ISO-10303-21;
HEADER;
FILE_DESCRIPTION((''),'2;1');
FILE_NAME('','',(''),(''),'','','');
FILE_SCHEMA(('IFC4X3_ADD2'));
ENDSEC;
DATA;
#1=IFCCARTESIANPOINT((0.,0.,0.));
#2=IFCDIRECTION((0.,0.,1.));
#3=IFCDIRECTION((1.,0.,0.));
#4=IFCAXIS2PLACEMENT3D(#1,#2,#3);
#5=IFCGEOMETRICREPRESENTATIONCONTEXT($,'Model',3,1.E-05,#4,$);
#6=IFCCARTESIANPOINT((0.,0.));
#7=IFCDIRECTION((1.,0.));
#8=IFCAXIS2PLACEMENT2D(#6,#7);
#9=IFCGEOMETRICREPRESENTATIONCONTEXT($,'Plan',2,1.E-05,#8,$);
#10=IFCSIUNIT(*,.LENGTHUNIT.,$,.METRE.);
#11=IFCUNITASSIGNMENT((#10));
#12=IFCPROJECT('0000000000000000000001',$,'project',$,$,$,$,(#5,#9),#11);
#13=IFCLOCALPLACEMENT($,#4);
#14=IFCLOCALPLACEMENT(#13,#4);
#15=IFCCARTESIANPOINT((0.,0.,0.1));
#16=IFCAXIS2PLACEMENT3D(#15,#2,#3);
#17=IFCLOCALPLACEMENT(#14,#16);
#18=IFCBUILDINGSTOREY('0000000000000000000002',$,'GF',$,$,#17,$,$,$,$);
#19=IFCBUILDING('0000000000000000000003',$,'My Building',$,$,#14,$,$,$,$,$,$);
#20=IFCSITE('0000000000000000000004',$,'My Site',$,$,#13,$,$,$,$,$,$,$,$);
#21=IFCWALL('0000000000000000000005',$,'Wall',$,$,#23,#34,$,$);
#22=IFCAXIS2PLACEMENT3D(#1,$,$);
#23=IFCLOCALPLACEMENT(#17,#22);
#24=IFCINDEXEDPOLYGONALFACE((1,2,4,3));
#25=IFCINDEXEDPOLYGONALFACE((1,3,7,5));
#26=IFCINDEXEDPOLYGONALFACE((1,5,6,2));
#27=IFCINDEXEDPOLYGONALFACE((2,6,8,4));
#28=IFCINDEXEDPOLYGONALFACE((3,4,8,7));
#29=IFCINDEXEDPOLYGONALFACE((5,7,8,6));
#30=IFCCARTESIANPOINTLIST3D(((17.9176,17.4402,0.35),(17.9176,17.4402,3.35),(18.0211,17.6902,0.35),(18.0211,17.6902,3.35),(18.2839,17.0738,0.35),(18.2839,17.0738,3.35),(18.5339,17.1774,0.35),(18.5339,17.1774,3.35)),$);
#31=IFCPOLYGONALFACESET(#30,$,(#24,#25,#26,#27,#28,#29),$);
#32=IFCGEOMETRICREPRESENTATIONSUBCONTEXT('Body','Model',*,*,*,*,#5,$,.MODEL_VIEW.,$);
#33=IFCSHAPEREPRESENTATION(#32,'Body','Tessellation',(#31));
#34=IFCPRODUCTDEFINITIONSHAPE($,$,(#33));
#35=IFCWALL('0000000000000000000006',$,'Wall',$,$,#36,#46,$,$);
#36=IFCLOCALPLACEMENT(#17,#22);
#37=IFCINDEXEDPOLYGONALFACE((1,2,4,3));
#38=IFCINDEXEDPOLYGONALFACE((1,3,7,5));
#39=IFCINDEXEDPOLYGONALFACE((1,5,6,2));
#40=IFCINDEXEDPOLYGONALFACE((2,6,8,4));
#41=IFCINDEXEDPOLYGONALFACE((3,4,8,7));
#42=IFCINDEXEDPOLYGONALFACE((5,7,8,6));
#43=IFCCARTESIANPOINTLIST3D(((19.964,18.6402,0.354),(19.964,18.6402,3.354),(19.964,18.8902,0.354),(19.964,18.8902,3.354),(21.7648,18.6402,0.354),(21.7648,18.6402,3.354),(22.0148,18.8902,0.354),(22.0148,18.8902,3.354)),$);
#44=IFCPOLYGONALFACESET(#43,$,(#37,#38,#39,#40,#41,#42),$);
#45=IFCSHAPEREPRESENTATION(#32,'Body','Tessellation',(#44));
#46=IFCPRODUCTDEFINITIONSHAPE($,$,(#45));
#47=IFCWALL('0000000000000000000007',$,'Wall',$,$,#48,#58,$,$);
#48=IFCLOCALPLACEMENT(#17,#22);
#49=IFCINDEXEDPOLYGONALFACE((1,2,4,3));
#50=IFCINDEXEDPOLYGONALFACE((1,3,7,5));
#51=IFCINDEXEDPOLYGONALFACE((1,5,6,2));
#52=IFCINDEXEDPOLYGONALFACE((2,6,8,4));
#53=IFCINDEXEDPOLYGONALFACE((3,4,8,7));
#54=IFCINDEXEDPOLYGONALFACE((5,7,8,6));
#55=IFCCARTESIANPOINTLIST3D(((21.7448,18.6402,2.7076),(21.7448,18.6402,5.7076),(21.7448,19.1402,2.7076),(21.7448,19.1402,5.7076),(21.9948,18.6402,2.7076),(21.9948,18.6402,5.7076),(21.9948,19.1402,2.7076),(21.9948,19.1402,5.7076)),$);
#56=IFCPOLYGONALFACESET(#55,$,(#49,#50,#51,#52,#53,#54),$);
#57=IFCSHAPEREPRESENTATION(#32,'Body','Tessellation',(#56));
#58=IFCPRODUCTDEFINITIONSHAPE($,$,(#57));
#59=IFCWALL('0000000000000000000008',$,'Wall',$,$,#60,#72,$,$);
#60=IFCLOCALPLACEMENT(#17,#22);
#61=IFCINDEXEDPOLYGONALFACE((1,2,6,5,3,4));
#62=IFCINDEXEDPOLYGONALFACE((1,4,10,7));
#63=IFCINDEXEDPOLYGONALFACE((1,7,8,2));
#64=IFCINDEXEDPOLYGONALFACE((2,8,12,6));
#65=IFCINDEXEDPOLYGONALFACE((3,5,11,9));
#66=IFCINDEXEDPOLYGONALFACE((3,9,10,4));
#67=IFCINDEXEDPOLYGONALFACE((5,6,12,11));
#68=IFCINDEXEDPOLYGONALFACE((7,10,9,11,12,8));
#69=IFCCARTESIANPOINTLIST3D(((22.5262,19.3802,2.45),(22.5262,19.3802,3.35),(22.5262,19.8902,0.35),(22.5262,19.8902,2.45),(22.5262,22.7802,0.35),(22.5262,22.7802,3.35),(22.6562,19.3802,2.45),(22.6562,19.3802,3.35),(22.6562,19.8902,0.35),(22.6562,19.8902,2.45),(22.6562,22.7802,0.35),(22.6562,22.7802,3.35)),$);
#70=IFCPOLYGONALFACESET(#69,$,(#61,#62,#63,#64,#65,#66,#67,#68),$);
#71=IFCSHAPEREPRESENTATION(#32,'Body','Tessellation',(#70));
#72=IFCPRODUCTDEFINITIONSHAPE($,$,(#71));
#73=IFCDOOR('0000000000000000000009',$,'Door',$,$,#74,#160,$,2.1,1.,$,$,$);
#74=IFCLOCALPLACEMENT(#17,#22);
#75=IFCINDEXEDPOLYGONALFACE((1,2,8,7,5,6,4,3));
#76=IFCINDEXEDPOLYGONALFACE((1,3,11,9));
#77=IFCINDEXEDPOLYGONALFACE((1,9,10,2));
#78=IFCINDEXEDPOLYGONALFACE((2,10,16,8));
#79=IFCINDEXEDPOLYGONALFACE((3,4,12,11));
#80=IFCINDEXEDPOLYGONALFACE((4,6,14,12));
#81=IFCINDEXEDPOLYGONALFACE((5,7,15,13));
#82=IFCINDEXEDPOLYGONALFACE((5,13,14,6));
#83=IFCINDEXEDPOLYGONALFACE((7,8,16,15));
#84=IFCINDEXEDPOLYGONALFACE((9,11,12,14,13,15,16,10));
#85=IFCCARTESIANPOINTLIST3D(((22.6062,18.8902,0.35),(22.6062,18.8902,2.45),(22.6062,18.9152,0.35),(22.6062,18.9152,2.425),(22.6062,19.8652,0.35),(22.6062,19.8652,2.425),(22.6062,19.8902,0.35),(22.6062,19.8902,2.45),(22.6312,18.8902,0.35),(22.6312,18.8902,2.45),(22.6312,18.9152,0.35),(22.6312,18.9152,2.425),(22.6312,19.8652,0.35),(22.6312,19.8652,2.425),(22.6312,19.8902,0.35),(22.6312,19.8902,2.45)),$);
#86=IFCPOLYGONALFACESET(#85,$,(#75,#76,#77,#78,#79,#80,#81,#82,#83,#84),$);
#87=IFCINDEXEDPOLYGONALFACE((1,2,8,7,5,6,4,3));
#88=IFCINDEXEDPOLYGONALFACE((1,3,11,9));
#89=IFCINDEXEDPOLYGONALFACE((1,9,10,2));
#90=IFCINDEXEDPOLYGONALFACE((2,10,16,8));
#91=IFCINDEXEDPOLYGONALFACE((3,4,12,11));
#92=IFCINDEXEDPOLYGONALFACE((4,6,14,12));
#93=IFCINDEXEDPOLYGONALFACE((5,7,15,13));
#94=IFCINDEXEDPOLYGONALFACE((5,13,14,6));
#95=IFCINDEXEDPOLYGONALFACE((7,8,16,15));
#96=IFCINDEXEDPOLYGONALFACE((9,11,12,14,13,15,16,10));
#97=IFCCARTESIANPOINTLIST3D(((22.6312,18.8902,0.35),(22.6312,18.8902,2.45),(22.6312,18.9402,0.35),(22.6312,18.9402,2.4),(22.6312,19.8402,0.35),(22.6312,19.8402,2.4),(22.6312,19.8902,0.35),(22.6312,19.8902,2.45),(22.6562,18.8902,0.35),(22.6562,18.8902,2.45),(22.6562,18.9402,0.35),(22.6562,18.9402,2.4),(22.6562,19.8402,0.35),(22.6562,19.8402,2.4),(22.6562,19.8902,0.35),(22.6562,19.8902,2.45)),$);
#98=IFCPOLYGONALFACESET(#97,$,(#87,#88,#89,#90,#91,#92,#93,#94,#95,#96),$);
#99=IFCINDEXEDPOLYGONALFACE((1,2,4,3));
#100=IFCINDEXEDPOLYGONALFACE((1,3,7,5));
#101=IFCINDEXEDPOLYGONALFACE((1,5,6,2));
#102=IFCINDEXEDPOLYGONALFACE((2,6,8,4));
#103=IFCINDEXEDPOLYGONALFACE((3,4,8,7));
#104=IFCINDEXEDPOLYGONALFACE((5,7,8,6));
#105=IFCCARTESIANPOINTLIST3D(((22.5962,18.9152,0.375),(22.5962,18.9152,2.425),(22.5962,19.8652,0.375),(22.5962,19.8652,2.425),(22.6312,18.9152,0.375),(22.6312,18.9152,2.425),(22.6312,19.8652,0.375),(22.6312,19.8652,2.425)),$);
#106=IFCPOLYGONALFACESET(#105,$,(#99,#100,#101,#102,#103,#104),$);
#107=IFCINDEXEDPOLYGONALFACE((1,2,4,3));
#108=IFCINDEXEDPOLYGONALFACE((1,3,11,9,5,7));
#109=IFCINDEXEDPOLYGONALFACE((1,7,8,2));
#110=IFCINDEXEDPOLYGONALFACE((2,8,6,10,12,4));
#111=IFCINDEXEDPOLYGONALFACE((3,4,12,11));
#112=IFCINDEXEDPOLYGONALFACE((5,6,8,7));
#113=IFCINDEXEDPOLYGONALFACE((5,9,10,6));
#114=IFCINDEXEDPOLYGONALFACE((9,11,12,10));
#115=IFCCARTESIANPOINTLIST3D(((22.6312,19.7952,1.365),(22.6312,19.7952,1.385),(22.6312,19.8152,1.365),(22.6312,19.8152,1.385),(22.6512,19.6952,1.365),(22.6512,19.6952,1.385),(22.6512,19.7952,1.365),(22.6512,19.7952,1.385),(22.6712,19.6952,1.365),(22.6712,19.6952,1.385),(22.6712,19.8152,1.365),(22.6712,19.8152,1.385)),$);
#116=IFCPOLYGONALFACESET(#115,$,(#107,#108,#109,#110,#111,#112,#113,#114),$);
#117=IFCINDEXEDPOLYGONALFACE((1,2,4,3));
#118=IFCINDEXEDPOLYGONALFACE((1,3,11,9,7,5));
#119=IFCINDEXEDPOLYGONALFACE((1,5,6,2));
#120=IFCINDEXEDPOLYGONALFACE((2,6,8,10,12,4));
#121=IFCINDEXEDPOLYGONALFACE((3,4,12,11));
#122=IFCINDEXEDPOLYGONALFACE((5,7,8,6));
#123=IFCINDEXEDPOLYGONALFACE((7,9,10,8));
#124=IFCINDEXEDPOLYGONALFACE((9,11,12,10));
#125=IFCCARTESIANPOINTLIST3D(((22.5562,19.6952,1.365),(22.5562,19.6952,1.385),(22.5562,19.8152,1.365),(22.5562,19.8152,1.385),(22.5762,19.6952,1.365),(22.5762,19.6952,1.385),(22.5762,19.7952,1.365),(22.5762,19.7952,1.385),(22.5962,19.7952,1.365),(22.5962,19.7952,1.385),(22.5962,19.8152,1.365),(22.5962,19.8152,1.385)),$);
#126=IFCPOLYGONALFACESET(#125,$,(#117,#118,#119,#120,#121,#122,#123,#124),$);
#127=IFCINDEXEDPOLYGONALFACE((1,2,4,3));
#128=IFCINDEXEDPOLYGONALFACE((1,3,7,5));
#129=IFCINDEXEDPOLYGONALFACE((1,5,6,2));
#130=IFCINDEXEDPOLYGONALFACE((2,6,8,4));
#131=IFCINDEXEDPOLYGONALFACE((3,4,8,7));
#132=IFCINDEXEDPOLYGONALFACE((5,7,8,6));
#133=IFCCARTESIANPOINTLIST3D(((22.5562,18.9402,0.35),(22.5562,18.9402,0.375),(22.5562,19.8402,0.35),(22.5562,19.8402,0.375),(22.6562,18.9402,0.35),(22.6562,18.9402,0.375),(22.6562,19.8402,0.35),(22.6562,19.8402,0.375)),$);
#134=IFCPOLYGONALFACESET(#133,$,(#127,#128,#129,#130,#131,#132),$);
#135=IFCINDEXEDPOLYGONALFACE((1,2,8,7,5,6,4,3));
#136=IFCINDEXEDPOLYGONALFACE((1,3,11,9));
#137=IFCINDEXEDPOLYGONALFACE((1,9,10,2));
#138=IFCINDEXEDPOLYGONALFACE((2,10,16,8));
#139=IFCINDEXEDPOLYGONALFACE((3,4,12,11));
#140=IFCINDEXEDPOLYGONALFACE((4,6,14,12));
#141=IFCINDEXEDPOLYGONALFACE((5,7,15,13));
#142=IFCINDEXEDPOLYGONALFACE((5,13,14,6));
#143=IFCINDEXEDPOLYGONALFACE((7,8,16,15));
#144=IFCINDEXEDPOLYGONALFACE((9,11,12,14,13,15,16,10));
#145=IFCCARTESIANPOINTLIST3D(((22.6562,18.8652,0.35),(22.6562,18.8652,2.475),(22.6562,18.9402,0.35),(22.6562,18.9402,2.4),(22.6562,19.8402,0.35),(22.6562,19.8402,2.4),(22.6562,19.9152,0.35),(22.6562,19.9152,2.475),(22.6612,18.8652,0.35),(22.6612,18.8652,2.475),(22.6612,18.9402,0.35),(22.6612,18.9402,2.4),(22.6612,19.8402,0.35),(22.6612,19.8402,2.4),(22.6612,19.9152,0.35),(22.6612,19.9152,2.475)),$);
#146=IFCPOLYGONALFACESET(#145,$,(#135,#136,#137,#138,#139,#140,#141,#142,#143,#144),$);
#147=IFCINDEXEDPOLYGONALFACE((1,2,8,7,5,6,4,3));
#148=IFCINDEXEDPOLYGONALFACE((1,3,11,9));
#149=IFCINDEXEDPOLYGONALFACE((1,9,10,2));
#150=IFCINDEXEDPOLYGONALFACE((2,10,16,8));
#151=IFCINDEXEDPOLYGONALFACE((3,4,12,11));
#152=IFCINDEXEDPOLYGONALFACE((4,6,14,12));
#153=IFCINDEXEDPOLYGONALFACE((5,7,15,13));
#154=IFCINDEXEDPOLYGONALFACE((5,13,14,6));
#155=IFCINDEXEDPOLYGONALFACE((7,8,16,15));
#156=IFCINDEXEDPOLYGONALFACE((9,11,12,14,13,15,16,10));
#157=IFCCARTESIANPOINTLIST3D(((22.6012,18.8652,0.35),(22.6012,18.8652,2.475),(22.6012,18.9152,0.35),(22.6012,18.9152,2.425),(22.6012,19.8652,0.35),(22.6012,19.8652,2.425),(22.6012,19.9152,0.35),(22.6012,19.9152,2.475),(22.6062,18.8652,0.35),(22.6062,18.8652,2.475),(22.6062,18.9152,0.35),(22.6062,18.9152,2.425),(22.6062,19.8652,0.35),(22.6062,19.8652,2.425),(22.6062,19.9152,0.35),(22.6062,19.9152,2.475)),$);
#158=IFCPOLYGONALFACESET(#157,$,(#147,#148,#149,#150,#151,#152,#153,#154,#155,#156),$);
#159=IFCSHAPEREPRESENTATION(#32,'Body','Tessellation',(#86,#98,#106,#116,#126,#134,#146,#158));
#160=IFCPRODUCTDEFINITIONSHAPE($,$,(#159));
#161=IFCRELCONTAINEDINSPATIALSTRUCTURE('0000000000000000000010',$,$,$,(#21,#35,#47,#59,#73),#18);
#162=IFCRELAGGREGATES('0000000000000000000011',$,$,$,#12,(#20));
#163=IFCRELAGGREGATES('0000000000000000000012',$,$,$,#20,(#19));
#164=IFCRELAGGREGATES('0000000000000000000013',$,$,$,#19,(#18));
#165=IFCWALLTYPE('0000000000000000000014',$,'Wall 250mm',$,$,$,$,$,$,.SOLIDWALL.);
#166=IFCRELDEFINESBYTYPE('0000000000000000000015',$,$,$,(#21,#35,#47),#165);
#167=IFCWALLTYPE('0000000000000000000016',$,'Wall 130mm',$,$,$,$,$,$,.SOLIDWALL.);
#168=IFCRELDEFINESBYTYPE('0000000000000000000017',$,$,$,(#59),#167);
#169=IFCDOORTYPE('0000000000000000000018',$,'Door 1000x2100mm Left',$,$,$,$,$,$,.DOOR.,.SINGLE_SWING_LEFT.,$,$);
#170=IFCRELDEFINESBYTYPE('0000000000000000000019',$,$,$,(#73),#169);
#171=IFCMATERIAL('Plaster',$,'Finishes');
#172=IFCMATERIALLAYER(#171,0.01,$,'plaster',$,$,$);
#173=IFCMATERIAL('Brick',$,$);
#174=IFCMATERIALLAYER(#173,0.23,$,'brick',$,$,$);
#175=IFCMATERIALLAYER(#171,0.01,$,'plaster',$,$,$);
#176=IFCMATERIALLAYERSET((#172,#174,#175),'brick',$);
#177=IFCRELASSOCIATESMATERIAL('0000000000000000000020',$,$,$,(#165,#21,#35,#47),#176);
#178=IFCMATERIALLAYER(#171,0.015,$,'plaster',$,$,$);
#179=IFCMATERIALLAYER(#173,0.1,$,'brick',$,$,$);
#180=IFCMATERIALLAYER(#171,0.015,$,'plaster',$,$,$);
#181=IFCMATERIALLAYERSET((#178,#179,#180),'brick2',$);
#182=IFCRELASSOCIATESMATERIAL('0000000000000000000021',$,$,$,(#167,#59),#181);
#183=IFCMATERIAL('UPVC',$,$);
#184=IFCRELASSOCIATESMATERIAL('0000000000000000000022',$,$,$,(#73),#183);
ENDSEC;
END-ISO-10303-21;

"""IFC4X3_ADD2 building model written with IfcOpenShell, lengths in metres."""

from ifc_helpers import new_model, entity, si_unit, frame, origin_with_axes, origin_2d_with_axis, place, context, subcontext, project, spatial, line, indexed_curve, outline, extrude, shape, source, transform, mapped, material, layer, layer_set, layer_usage, type_object, type_shapes, element, fill, save


model = new_model("IFC4X3_ADD2")

# Units and contexts
model_context = context("Model", 3, precision=1e-05, world=origin_with_axes())
plan_context = context("Plan", 2, precision=1e-05, world=origin_2d_with_axis())
body_context_1 = subcontext(model_context, "Body", "Model", "MODEL_VIEW")
body_context_2 = subcontext(plan_context, "Body", "Plan", "PLAN_VIEW")
ifc_project = project(units=[si_unit("LENGTHUNIT", "METRE")], contexts=[model_context, plan_context])

# Site, building, storey
site_placement = place(None, origin_with_axes())
site = spatial("IfcSite", under=ifc_project, at=site_placement, Name="My Site")
building_placement = place(site_placement, origin_with_axes())
building = spatial("IfcBuilding", under=site, at=building_placement, Name="My Building")
storey_placement = place(building_placement, frame((0.0, 0.0, 0.1), z_axis=(0.0, 0.0, 1.0), x_axis=(1.0, 0.0, 0.0)))
storey = spatial("IfcBuildingStorey", under=building, at=storey_placement, Name="GF")

# Shared definitions
ifc_material_1 = material(Name="UPVC")

# Shared definitions
ifc_material_2 = material(Name="Plaster", Category="Finishes")
ifc_layer_1 = layer(ifc_material_2, 0.01, Name="plaster")
ifc_material_3 = material(Name="Brick")
ifc_layer_2 = layer(ifc_material_3, 0.23, Name="brick")
ifc_layer_3 = layer(ifc_material_2, 0.01, Name="plaster")
ifc_layer_set_1 = layer_set([ifc_layer_1, ifc_layer_2, ifc_layer_3], Name="brick")
wall_type_1 = type_object("IfcWallType", Name="Wall 250mm", PredefinedType="SOLIDWALL", material=ifc_layer_set_1)

# Shared definitions
shared_shape_1 = source(origin_with_axes(), body_context_1, "Body", "SweptSolid", [
    extrude(outline(indexed_curve([(0.0, 0.0), (1.0, 0.0), (1.0, 2.1), (0.0, 2.1)], segments=[line(1, 2, 3, 4, 1)])), frame((0.0, -0.6, 0.0), z_axis=(0.0, -1.0, 0.0), x_axis=(1.0, 0.0, 0.0)), (0.0, 0.0, -1.0), 1.2),
])
door_type_1 = type_object("IfcDoorType", Name="Door 1000x2100mm Left", OperationType="SINGLE_SWING_LEFT", PredefinedType="DOOR")
shared_shape_2 = source(origin_with_axes(), body_context_1, "Body", "SweptSolid", [
    extrude(outline(indexed_curve([(0.0, 0.0), (0.0, 2.1), (1.0, 2.1), (1.0, 0.0), (0.975, 0.0), (0.975, 2.075), (0.025, 2.075), (0.025, 0.0)], segments=[line(1, 2, 3, 4, 5, 6, 7, 8, 1)])), frame((0.0, 0.025, 0.0), z_axis=(0.0, -1.0, 0.0), x_axis=(1.0, 0.0, 0.0)), (0.0, 0.0, -1.0), 0.025),
    extrude(outline(indexed_curve([(0.0, 0.0), (0.0, 2.1), (1.0, 2.1), (1.0, 0.0), (0.95, 0.0), (0.95, 2.05), (0.05, 2.05), (0.05, 0.0)], segments=[line(1, 2, 3, 4, 5, 6, 7, 8, 1)])), frame((0.0, 0.0, 0.0), z_axis=(0.0, -1.0, 0.0), x_axis=(1.0, 0.0, 0.0)), (0.0, 0.0, -1.0), 0.025),
    extrude(outline(indexed_curve([(0.0, 0.0), (0.95, 0.0), (0.95, 0.035), (0.0, 0.035)], segments=[line(1, 2, 3, 4, 1)])), frame((0.025, 0.025, 0.025), z_axis=(0.0, 0.0, 1.0), x_axis=(1.0, 0.0, 0.0)), (0.0, 0.0, 1.0), 2.05),
    extrude(outline(indexed_curve([(0.0, 0.0), (0.0, -0.04), (-0.12, -0.04), (-0.12, -0.02), (-0.02, -0.02), (-0.02, 0.0)], segments=[line(1, 2, 3, 4, 5, 6, 1)])), frame((0.925, 0.025, 1.015), z_axis=(0.0, 0.0, 1.0), x_axis=(1.0, 0.0, 0.0)), (0.0, 0.0, 1.0), 0.02),
    extrude(outline(indexed_curve([(0.0, 0.0), (0.0, 0.04), (-0.12, 0.04), (-0.12, 0.02), (-0.02, 0.02), (-0.02, 0.0)], segments=[line(1, 2, 3, 4, 5, 6, 1)])), frame((0.925, 0.06, 1.015), z_axis=(0.0, 0.0, 1.0), x_axis=(1.0, 0.0, 0.0)), (0.0, 0.0, 1.0), 0.02),
    extrude(outline(indexed_curve([(0.0, 0.0), (0.9, 0.0), (0.9, 0.1), (0.0, 0.1)], segments=[line(1, 2, 3, 4, 1)])), frame((0.05, 0.0, 0.0), z_axis=(0.0, 0.0, 1.0), x_axis=(1.0, 0.0, 0.0)), (0.0, 0.0, 1.0), 0.025),
    extrude(outline(indexed_curve([(0.0, 0.0), (0.0, 2.125), (1.05, 2.125), (1.05, 0.0), (0.975, 0.0), (0.975, 2.05), (0.075, 2.05), (0.075, 0.0)], segments=[line(1, 2, 3, 4, 5, 6, 7, 8, 1)])), frame((-0.025, -0.005, 0.0), z_axis=(0.0, -1.0, 0.0), x_axis=(1.0, 0.0, 0.0)), (0.0, 0.0, -1.0), 0.005),
    extrude(outline(indexed_curve([(0.0, 0.0), (0.0, 2.125), (1.05, 2.125), (1.05, 0.0), (1.0, 0.0), (1.0, 2.075), (0.05, 2.075), (0.05, 0.0)], segments=[line(1, 2, 3, 4, 5, 6, 7, 8, 1)])), frame((-0.025, 0.05, 0.0), z_axis=(0.0, -1.0, 0.0), x_axis=(1.0, 0.0, 0.0)), (0.0, 0.0, -1.0), 0.005),
])
shared_shape_3 = source(origin_with_axes(), body_context_2, "Body", "Curve2D", [
    entity("IfcIndexedPolyCurve", entity("IfcCartesianPointList2D", [[0.0, 0.0], [0.0, 0.05], [0.025, 0.05], [0.025, 0.025], [0.05, 0.025], [0.05, 0.0]]), [entity("IfcLineIndex", [1, 2, 3, 4, 5, 6, 1])]),
    entity("IfcIndexedPolyCurve", entity("IfcCartesianPointList2D", [[1.0, 0.0], [1.0, 0.05], [0.975, 0.05], [0.975, 0.025], [0.95, 0.025], [0.95, 0.0]]), [entity("IfcLineIndex", [1, 2, 3, 4, 5, 6, 1])]),
    entity("IfcTrimmedCurve", entity("IfcEllipse", entity("IfcAxis2Placement2D", entity("IfcCartesianPoint", [0.06, 0.05]), entity("IfcDirection", [1.0, 0.0])), 0.915, 0.95), [entity("IfcCartesianPoint", [0.975, 0.05])], [entity("IfcCartesianPoint", [0.06, 1.0])], True, "CARTESIAN"),
    entity("IfcIndexedPolyCurve", entity("IfcCartesianPointList2D", [[0.025, 0.05], [0.06, 0.05], [0.06, 1.0], [0.025, 1.0]]), [entity("IfcLineIndex", [1, 2, 3, 4, 1])]),
])
type_shapes(door_type_1, [shared_shape_2, shared_shape_3])

# Walls
ifc_layer_usage_1 = layer_usage(ifc_layer_set_1, "AXIS2", "NEGATIVE", 0.0)
wall_1_placement = place(storey_placement, frame((18.2839, 17.0738, 0.35), z_axis=(0.0, 0.0, 1.0), x_axis=(-0.707107, 0.707107, 0.0)))
element("IfcWall", 1, at=wall_1_placement, inside=storey, type_object=wall_type_1, material=ifc_layer_usage_1, Name="Wall", context=body_context_1, shape_type="SweptSolid", body=[
    extrude(outline(indexed_curve([(-0.1036, -0.25), (0.0, 0.0), (0.5181, 0.0), (0.6217, -0.25)], segments=[line(1, 2, 3, 4, 1)])), origin_with_axes(), (0.0, 0.0, 1.0), 3.0),
])
ifc_layer_usage_2 = layer_usage(ifc_layer_set_1, "AXIS2", "POSITIVE", 0.0)
wall_2_placement = place(storey_placement, frame((19.714, 18.6402, 0.354), z_axis=(0.0, 0.0, 1.0), x_axis=(1.0, -0.000001, 0.0)))
element("IfcWall", 2, at=wall_2_placement, inside=storey, type_object=wall_type_1, material=ifc_layer_usage_2, Name="Wall", context=body_context_1, shape_type="SweptSolid", body=[
    extrude(outline(indexed_curve([(0.25, 0.0), (0.25, 0.25), (2.3008, 0.25), (2.0508, 0.0)], segments=[line(1, 2, 3, 4, 1)])), origin_with_axes(), (0.0, 0.0, 1.0), 3.0),
])
ifc_layer_usage_3 = layer_usage(ifc_layer_set_1, "AXIS2", "POSITIVE", 0.0)
wall_3_placement = place(storey_placement, frame((21.9948, 18.6402, 2.7076), z_axis=(0.0, 0.0, 1.0), x_axis=(0.000001, 1.0, 0.0)))
element("IfcWall", 3, at=wall_3_placement, inside=storey, type_object=wall_type_1, material=ifc_layer_usage_3, Name="Wall", context=body_context_1, shape_type="SweptSolid", body=[
    extrude(outline(indexed_curve([(0.0, 0.0), (0.0, 0.25), (0.5, 0.25), (0.5, 0.0)], segments=[line(1, 2, 3, 4, 1)])), origin_with_axes(), (0.0, 0.0, 1.0), 3.0),
])
ifc_layer_4 = layer(ifc_material_2, 0.015, Name="plaster")
ifc_layer_5 = layer(ifc_material_3, 0.1, Name="brick")
ifc_layer_6 = layer(ifc_material_2, 0.015, Name="plaster")
ifc_layer_set_2 = layer_set([ifc_layer_4, ifc_layer_5, ifc_layer_6], Name="brick2")
wall_type_2 = type_object("IfcWallType", Name="Wall 130mm", PredefinedType="SOLIDWALL", material=ifc_layer_set_2)

# Wall, opening, door
ifc_layer_usage_4 = layer_usage(ifc_layer_set_2, "AXIS2", "POSITIVE", 0.0)
wall_4_placement = place(storey_placement, frame((22.6562, 19.3802, 0.35), z_axis=(0.0, 0.0, 1.0), x_axis=(0.000002, 1.0, 0.0)))
wall_4 = element("IfcWall", 4, at=wall_4_placement, inside=storey, type_object=wall_type_2, material=ifc_layer_usage_4, Name="Wall", context=body_context_1, shape_type="SweptSolid", body=[
    extrude(outline(indexed_curve([(0.0, 0.0), (0.0, 0.13), (3.4, 0.13), (3.4, 0.0)], segments=[line(1, 2, 3, 4, 1)])), origin_with_axes(), (0.0, 0.0, 1.0), 3.0),
])
opening_1_placement = place(wall_4_placement, frame((-0.49, 0.0, 0.0), z_axis=(0.0, 0.0, 1.0), x_axis=(1.0, 0.0, 0.0)))
opening_1 = element("IfcOpeningElement", 5, at=opening_1_placement, cuts=wall_4, PredefinedType="OPENING", context=body_context_1, shape_type="MappedRepresentation", body=[
    mapped(shared_shape_1, transform((0.0, 0.0, 0.0), x_axis=(1.0, 0.0, 0.0), y_axis=(0.0, 1.0, 0.0), z_axis=(0.0, 0.0, 1.0), scale=1.0)),
])
door_1_placement = place(opening_1_placement, frame((0.0, 0.0, 0.0), z_axis=(0.0, 0.0, 1.0), x_axis=(1.0, 0.0, 0.0)))
door_1 = element("IfcDoor", 6, at=door_1_placement, inside=storey, type_object=door_type_1, material=ifc_material_1, Name="Door", OverallHeight=2.1, OverallWidth=1.0, shapes=[
    shape(body_context_1, "Body", "MappedRepresentation", [mapped(shared_shape_2, transform((0.0, 0.0, 0.0), x_axis=(1.0, 0.0, 0.0), y_axis=(0.0, 1.0, 0.0), z_axis=(0.0, 0.0, 1.0), scale=1.0))]),
    shape(body_context_2, "Body", "MappedRepresentation", [mapped(shared_shape_3, transform((0.0, 0.0, 0.0), x_axis=(1.0, 0.0, 0.0), y_axis=(0.0, 1.0, 0.0), z_axis=(0.0, 0.0, 1.0), scale=1.0))]),
])
fill(opening_1, door_1)

save(model, "model.ifc")
